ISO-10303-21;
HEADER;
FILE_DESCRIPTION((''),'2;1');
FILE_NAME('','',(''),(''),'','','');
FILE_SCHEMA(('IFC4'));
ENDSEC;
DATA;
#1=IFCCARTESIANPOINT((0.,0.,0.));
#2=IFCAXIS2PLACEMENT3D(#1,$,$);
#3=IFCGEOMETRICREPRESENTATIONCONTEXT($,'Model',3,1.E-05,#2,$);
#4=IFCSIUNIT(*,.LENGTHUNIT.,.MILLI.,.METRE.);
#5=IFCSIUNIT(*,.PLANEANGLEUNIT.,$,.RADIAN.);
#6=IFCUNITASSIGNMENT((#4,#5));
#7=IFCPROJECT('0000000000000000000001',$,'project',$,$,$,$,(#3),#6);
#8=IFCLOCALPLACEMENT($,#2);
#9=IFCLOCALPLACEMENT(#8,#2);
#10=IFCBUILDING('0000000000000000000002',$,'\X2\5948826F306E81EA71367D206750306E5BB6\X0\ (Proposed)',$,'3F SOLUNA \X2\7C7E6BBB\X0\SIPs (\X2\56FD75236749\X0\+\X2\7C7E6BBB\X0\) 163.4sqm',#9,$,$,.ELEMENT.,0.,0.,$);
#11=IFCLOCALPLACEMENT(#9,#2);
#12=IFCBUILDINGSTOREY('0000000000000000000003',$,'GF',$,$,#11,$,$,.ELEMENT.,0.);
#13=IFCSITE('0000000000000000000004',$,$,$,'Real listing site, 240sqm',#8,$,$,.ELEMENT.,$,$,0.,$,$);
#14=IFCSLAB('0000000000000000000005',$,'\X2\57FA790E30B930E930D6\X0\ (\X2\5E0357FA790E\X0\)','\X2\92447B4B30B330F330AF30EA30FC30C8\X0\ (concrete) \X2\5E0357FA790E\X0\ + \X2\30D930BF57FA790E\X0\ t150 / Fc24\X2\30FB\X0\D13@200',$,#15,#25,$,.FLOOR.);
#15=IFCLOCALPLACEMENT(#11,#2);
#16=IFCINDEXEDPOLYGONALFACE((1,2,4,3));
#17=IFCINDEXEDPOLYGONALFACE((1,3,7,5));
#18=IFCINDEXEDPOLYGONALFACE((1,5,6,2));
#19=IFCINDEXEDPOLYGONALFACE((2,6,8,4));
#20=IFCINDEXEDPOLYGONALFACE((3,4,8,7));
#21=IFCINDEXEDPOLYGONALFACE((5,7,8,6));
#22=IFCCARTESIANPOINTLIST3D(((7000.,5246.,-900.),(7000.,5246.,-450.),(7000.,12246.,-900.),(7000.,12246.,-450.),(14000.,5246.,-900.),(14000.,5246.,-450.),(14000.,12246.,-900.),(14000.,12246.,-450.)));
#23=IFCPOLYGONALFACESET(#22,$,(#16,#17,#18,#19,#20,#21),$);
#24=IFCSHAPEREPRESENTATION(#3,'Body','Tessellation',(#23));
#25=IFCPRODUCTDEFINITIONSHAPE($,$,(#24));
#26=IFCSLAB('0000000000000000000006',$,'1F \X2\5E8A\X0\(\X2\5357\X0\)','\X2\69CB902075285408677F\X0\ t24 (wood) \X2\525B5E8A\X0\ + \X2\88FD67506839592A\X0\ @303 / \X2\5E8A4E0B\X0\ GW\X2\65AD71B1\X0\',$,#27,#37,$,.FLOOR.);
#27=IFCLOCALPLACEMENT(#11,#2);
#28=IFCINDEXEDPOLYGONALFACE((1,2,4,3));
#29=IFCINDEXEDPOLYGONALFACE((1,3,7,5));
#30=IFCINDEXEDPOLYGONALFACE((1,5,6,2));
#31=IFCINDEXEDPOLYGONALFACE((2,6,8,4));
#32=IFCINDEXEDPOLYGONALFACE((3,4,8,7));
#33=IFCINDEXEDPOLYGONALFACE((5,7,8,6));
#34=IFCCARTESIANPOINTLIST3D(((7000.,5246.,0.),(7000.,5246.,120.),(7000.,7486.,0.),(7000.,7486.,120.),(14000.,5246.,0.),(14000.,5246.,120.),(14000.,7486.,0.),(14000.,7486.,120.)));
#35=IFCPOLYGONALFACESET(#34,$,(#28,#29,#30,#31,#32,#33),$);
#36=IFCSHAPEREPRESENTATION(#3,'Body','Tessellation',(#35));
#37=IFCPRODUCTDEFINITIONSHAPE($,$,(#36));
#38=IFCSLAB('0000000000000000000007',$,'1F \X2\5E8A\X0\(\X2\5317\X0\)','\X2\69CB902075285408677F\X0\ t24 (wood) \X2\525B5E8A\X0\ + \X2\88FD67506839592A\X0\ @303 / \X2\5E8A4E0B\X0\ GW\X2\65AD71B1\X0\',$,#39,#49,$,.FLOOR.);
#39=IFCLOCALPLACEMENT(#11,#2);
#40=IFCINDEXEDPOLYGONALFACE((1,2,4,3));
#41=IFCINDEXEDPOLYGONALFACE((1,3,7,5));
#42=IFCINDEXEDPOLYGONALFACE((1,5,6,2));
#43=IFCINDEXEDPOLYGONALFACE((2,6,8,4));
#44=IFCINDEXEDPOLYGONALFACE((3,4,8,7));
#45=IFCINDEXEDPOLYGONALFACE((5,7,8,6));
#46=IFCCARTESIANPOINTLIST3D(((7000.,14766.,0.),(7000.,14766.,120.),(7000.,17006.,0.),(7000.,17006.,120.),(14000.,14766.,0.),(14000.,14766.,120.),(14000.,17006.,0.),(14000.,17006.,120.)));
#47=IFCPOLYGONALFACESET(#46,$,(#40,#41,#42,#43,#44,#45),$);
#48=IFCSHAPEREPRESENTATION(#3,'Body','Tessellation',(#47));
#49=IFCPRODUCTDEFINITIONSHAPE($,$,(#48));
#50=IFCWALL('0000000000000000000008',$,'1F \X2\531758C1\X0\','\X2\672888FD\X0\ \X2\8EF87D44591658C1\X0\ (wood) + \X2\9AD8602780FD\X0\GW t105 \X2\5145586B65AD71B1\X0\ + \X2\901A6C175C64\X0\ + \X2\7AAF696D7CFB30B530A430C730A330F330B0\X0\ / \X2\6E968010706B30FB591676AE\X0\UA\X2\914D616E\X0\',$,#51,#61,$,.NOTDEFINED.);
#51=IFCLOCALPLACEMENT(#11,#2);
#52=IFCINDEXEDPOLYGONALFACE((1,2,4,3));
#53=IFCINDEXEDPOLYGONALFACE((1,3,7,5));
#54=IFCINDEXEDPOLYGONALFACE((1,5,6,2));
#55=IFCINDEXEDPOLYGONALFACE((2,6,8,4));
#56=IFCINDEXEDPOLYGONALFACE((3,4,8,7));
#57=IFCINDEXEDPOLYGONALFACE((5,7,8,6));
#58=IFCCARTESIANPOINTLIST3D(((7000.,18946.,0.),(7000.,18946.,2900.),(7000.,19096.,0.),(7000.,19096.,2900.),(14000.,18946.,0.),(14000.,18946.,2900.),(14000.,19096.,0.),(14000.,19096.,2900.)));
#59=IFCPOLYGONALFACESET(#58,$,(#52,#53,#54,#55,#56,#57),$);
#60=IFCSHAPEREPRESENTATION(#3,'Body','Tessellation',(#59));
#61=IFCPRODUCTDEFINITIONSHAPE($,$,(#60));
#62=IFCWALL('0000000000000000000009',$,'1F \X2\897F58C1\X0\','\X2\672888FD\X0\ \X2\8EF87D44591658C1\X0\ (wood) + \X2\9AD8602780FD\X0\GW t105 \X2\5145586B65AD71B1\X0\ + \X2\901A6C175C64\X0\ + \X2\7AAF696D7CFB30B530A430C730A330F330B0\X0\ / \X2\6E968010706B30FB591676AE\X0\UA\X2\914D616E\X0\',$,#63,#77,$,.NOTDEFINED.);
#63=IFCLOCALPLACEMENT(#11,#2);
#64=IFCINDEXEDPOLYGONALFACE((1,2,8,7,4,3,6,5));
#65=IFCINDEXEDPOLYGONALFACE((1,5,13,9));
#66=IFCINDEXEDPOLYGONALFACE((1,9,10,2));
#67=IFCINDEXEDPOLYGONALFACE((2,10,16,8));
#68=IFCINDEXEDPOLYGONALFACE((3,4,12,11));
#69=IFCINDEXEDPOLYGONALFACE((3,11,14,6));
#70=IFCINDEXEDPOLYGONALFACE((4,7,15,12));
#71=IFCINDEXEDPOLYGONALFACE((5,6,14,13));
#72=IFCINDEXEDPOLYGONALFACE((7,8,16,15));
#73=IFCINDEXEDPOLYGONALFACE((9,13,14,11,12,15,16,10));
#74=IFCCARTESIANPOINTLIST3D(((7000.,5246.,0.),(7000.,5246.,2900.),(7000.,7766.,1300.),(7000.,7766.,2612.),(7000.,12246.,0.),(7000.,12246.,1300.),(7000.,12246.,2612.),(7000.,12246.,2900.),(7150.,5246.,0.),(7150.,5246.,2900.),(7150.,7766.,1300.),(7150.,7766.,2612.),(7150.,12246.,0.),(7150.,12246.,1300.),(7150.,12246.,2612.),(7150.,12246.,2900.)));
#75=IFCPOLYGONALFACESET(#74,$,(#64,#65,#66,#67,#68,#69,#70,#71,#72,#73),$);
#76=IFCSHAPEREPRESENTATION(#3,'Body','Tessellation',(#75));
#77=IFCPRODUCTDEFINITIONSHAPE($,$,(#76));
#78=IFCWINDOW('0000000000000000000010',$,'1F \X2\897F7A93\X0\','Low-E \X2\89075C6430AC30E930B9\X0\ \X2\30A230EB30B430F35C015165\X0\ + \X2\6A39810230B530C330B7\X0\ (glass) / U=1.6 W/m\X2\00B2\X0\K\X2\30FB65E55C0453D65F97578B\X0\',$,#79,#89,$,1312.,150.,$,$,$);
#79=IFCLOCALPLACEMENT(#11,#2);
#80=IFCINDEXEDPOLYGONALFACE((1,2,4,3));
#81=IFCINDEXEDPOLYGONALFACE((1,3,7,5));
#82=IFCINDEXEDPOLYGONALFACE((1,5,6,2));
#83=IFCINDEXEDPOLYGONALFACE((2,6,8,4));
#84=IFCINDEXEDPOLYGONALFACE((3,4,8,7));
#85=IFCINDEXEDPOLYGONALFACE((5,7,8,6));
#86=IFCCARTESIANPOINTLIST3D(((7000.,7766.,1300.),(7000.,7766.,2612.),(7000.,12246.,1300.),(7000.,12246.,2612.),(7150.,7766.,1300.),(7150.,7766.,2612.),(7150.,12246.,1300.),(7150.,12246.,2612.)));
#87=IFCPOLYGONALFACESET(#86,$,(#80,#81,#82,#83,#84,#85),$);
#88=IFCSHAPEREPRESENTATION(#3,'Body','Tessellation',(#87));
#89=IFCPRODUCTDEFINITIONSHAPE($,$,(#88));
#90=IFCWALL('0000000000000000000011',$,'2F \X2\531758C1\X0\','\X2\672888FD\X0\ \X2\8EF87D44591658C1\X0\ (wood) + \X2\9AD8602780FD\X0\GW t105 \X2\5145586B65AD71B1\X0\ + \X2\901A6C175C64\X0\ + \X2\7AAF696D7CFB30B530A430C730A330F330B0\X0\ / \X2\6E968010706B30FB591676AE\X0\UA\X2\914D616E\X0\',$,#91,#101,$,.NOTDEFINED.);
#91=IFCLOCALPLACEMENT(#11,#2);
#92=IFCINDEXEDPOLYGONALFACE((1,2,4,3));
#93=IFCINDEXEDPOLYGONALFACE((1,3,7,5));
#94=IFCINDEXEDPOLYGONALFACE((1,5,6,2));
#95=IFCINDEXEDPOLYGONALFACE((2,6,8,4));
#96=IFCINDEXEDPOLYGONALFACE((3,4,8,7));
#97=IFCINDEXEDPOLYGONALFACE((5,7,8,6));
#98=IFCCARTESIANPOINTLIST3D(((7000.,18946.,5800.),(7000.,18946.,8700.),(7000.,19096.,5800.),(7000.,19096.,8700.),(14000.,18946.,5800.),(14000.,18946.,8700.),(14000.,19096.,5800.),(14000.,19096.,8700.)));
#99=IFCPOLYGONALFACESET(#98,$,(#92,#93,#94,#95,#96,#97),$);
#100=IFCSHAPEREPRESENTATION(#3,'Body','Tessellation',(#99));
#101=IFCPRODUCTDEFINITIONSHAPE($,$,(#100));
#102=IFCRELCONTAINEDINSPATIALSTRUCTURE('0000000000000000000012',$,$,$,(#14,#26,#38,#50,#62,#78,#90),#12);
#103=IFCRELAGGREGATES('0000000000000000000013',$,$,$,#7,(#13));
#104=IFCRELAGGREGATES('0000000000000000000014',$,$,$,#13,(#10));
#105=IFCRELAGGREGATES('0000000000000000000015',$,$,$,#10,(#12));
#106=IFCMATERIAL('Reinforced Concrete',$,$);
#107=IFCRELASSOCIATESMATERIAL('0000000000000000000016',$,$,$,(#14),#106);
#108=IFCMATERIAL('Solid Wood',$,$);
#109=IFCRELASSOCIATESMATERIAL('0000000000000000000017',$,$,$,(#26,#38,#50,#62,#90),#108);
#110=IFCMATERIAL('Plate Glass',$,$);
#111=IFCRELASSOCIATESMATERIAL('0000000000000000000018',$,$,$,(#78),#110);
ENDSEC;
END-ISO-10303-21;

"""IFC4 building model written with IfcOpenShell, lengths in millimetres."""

from ifc_helpers import new_model, si_unit, frame, frame_2d, origin, place, context, project, spatial, rectangle, extrude, material, element, fill, save


model = new_model("IFC4")

# Units and contexts
model_context = context("Model", 3, precision=1e-05, world=origin())
ifc_project = project(units=[si_unit("LENGTHUNIT", "METRE", prefix="MILLI"), si_unit("PLANEANGLEUNIT", "RADIAN")], contexts=[model_context])

# Site, building, storey
site_placement = place(None, origin())
site = spatial("IfcSite", under=ifc_project, at=site_placement, ObjectType="Real listing site, 240sqm", CompositionType="ELEMENT", RefElevation=0.0)
building_placement = place(site_placement, origin())
building = spatial("IfcBuilding", under=site, at=building_placement, Name="奈良の自然素材の家 (Proposed)", ObjectType="3F SOLUNA 籾殻SIPs (国産杉+籾殻) 163.4sqm", CompositionType="ELEMENT", ElevationOfRefHeight=0.0, ElevationOfTerrain=0.0)
storey_placement = place(building_placement, origin())
storey = spatial("IfcBuildingStorey", under=building, at=storey_placement, Name="GF", CompositionType="ELEMENT", Elevation=0.0)

# Slabs
ifc_material_1 = material(Name="Reinforced Concrete")
slab_1_placement = place(storey_placement, frame((3500.0, 2623.0, -450.0)))
element("IfcSlab", 1, at=slab_1_placement, inside=storey, material=ifc_material_1, Name="基礎スラブ (布基礎)", Description="鉄筋コンクリート (concrete) 布基礎 + ベタ基礎 t150 / Fc24・D13@200", PredefinedType="FLOOR", context=model_context, shape_type="SweptSolid", body=[
    extrude(rectangle(XDim=7000.0, YDim=7000.0, at=frame_2d((3500.0, 3500.0))), frame((3500.0, 2623.0, -450.0)), (0.0, 0.0, 1.0), 450.0),
])
ifc_material_2 = material(Name="Solid Wood")
slab_2_placement = place(storey_placement, frame((3500.0, 2623.0, 0.0)))
element("IfcSlab", 2, at=slab_2_placement, inside=storey, material=ifc_material_2, Name="1F 床(南)", Description="構造用合板 t24 (wood) 剛床 + 製材根太 @303 / 床下 GW断熱", PredefinedType="FLOOR", context=model_context, shape_type="SweptSolid", body=[
    extrude(rectangle(XDim=7000.0, YDim=2240.0, at=frame_2d((3500.0, 1120.0))), frame((3500.0, 2623.0, 0.0)), (0.0, 0.0, 1.0), 120.0),
])
slab_3_placement = place(storey_placement, frame((3500.0, 7383.0, 0.0)))
element("IfcSlab", 3, at=slab_3_placement, inside=storey, material=ifc_material_2, Name="1F 床(北)", Description="構造用合板 t24 (wood) 剛床 + 製材根太 @303 / 床下 GW断熱", PredefinedType="FLOOR", context=model_context, shape_type="SweptSolid", body=[
    extrude(rectangle(XDim=7000.0, YDim=2240.0, at=frame_2d((3500.0, 1120.0))), frame((3500.0, 7383.0, 0.0)), (0.0, 0.0, 1.0), 120.0),
])

# Shared definitions
ifc_material_3 = material(Name="Plate Glass")

# Wall
wall_1_placement = place(storey_placement, frame((3500.0, 9473.0, 0.0)))
element("IfcWall", 4, at=wall_1_placement, inside=storey, material=ifc_material_2, Name="1F 北壁", Description="木製 軸組外壁 (wood) + 高性能GW t105 充填断熱 + 通気層 + 窯業系サイディング / 準耐火・外皮UA配慮", PredefinedType="NOTDEFINED", context=model_context, shape_type="SweptSolid", body=[
    extrude(rectangle(XDim=7000.0, YDim=150.0, at=frame_2d((3500.0, 75.0))), frame((3500.0, 9473.0, 0.0)), (0.0, 0.0, 1.0), 2900.0),
])

# Wall, opening, window
wall_2_placement = place(storey_placement, frame((3500.0, 2623.0, 0.0)))
wall_2 = element("IfcWall", 5, at=wall_2_placement, inside=storey, material=ifc_material_2, Name="1F 西壁", Description="木製 軸組外壁 (wood) + 高性能GW t105 充填断熱 + 通気層 + 窯業系サイディング / 準耐火・外皮UA配慮", PredefinedType="NOTDEFINED", context=model_context, shape_type="SweptSolid", body=[
    extrude(rectangle(XDim=150.0, YDim=7000.0, at=frame_2d((75.0, 3500.0))), frame((3500.0, 2623.0, 0.0)), (0.0, 0.0, 1.0), 2900.0),
])
opening_1_placement = place(storey_placement, frame((3500.0, 3883.0, 650.0)))
opening_1 = element("IfcOpeningElement", 6, at=opening_1_placement, cuts=wall_2, PredefinedType="NOTDEFINED", context=model_context, shape_type="SweptSolid", body=[
    extrude(rectangle(XDim=150.0, YDim=4480.0, at=frame_2d((75.0, 2240.0))), frame((3500.0, 3883.0, 650.0)), (0.0, 0.0, 1.0), 1312.0),
])
window_1_placement = place(storey_placement, frame((3500.0, 3883.0, 650.0)))
window_1 = element("IfcWindow", 7, at=window_1_placement, inside=storey, material=ifc_material_3, Name="1F 西窓", Description="Low-E 複層ガラス アルゴン封入 + 樹脂サッシ (glass) / U=1.6 W/m²K・日射取得型", OverallHeight=1312.0, OverallWidth=150.0, context=model_context, shape_type="SweptSolid", body=[
    extrude(rectangle(XDim=150.0, YDim=4480.0, at=frame_2d((75.0, 2240.0))), frame((3500.0, 3883.0, 650.0)), (0.0, 0.0, 1.0), 1312.0),
])
fill(opening_1, window_1)

# Wall
wall_3_placement = place(storey_placement, frame((3500.0, 9473.0, 2900.0)))
element("IfcWall", 8, at=wall_3_placement, inside=storey, material=ifc_material_2, Name="2F 北壁", Description="木製 軸組外壁 (wood) + 高性能GW t105 充填断熱 + 通気層 + 窯業系サイディング / 準耐火・外皮UA配慮", PredefinedType="NOTDEFINED", context=model_context, shape_type="SweptSolid", body=[
    extrude(rectangle(XDim=7000.0, YDim=150.0, at=frame_2d((3500.0, 75.0))), frame((3500.0, 9473.0, 2900.0)), (0.0, 0.0, 1.0), 2900.0),
])

save(model, "model.ifc")
